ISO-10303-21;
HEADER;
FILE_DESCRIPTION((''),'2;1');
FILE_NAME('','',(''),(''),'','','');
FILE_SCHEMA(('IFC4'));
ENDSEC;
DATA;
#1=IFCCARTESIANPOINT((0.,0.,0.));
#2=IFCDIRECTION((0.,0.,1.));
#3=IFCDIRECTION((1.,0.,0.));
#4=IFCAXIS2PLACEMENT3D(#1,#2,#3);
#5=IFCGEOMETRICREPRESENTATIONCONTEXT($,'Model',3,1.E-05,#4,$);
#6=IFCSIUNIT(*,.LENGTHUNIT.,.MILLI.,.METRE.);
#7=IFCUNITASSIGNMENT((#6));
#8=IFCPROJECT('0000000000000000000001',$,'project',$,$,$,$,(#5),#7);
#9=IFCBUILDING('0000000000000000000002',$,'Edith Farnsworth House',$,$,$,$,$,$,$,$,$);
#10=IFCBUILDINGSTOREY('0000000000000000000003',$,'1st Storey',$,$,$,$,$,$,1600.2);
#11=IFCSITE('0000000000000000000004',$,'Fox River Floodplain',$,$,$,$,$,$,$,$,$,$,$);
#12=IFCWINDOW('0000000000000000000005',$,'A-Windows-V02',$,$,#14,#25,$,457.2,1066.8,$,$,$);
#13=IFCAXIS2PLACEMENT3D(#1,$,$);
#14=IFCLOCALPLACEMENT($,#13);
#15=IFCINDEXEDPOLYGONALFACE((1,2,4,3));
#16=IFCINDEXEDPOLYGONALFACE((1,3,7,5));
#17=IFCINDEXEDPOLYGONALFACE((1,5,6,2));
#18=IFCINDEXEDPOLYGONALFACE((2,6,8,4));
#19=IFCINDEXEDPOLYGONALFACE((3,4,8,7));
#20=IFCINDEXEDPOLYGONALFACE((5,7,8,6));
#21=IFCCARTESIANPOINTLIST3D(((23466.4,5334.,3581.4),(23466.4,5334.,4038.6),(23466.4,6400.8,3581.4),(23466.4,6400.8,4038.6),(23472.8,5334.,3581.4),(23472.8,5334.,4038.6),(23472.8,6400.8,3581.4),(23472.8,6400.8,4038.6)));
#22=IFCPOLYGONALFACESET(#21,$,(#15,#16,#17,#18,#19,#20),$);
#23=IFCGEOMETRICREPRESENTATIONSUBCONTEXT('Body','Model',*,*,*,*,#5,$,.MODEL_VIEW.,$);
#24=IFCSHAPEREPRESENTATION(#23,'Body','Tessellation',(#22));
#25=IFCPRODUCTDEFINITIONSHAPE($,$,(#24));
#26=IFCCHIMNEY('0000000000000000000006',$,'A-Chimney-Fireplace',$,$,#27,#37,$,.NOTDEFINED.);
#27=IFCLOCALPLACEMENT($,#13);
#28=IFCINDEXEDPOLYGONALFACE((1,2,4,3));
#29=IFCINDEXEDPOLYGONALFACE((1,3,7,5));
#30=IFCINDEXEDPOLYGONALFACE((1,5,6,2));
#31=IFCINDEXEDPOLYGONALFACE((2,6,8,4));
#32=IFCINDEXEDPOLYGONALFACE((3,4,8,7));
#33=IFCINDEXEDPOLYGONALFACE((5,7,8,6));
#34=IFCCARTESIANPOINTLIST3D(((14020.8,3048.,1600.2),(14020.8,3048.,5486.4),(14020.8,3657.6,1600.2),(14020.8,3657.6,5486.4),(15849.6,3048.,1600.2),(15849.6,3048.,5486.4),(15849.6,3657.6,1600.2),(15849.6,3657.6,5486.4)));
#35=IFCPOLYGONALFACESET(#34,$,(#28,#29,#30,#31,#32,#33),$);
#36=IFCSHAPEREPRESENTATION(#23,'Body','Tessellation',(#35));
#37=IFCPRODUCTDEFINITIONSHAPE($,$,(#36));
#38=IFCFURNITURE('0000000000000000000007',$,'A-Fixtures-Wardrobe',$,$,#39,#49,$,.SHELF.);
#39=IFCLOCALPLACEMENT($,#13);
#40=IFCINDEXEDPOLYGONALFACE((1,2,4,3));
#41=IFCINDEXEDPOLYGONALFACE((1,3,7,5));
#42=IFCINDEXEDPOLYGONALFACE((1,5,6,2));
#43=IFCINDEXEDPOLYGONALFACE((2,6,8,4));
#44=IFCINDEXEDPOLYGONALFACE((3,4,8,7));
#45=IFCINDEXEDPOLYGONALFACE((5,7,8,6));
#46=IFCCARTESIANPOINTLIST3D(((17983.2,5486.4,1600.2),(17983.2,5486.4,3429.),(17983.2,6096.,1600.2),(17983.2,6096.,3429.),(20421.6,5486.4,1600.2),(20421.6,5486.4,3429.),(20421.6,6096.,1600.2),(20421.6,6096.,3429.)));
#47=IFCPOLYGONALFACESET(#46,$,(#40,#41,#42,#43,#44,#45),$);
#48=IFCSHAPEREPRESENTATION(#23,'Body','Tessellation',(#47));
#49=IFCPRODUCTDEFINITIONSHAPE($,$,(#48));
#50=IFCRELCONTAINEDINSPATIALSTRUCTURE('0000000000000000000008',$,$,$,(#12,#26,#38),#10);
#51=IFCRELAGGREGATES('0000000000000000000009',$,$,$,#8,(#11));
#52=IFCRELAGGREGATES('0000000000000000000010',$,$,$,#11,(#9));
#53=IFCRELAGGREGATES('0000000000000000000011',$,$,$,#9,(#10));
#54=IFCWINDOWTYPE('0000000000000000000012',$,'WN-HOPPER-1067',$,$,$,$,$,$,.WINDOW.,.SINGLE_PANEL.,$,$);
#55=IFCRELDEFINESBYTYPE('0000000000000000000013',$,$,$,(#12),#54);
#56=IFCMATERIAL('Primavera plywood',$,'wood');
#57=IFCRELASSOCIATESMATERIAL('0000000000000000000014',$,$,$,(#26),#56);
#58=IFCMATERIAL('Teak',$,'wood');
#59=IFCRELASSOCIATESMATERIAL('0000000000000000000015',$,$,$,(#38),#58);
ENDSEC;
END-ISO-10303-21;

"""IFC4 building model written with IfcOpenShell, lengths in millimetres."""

from ifc_helpers import new_model, si_unit, frame, origin, origin_with_axes, place, context, subcontext, project, spatial, rectangle, extrude, material, type_object, element, save


model = new_model("IFC4")

# Units and contexts
model_context = context("Model", 3, precision=1e-05, world=origin_with_axes())
body_context = subcontext(model_context, "Body", "Model", "MODEL_VIEW")
ifc_project = project(units=[si_unit("LENGTHUNIT", "METRE", prefix="MILLI")], contexts=[model_context])

# Site, building, storey
site = spatial("IfcSite", under=ifc_project, Name="Fox River Floodplain")
building = spatial("IfcBuilding", under=site, Name="Edith Farnsworth House")
storey = spatial("IfcBuildingStorey", under=building, Name="1st Storey", Elevation=1600.2)

# Shared definitions
ifc_material_1 = material(Name="Primavera plywood", Category="wood")

# Window
window_type = type_object("IfcWindowType", Name="WN-HOPPER-1067", PartitioningType="SINGLE_PANEL", PredefinedType="WINDOW")
window_1_placement = place(None, frame((23469.6, 5867.4, 3581.4), z_axis=(0.0, 0.0, 1.0), x_axis=(0.0, 1.0, 0.0)))
element("IfcWindow", 1, at=window_1_placement, inside=storey, type_object=window_type, Name="A-Windows-V02", OverallHeight=457.2, OverallWidth=1066.8, context=body_context, shape_type="SweptSolid", body=[
    extrude(rectangle(XDim=1066.8, YDim=6.3), origin(), (0.0, 0.0, 1.0), 457.2),
])

# Chimney
chimney_placement = place(None, frame((14935.2, 3352.8, 1600.2), z_axis=(0.0, 0.0, 1.0), x_axis=(1.0, 0.0, 0.0)))
element("IfcChimney", 2, at=chimney_placement, inside=storey, material=ifc_material_1, Name="A-Chimney-Fireplace", PredefinedType="NOTDEFINED", context=body_context, shape_type="SweptSolid", body=[
    extrude(rectangle(XDim=1828.8, YDim=609.6), origin(), (0.0, 0.0, 1.0), 3886.2),
])

# Furniture
ifc_material_2 = material(Name="Teak", Category="wood")
furniture_placement = place(None, frame((19202.4, 5791.2, 1600.2), z_axis=(0.0, 0.0, 1.0), x_axis=(1.0, 0.0, 0.0)))
element("IfcFurniture", 3, at=furniture_placement, inside=storey, material=ifc_material_2, Name="A-Fixtures-Wardrobe", PredefinedType="SHELF", context=body_context, shape_type="SweptSolid", body=[
    extrude(rectangle(XDim=2438.4, YDim=609.6), origin(), (0.0, 0.0, 1.0), 1828.8),
])

save(model, "model.ifc")
